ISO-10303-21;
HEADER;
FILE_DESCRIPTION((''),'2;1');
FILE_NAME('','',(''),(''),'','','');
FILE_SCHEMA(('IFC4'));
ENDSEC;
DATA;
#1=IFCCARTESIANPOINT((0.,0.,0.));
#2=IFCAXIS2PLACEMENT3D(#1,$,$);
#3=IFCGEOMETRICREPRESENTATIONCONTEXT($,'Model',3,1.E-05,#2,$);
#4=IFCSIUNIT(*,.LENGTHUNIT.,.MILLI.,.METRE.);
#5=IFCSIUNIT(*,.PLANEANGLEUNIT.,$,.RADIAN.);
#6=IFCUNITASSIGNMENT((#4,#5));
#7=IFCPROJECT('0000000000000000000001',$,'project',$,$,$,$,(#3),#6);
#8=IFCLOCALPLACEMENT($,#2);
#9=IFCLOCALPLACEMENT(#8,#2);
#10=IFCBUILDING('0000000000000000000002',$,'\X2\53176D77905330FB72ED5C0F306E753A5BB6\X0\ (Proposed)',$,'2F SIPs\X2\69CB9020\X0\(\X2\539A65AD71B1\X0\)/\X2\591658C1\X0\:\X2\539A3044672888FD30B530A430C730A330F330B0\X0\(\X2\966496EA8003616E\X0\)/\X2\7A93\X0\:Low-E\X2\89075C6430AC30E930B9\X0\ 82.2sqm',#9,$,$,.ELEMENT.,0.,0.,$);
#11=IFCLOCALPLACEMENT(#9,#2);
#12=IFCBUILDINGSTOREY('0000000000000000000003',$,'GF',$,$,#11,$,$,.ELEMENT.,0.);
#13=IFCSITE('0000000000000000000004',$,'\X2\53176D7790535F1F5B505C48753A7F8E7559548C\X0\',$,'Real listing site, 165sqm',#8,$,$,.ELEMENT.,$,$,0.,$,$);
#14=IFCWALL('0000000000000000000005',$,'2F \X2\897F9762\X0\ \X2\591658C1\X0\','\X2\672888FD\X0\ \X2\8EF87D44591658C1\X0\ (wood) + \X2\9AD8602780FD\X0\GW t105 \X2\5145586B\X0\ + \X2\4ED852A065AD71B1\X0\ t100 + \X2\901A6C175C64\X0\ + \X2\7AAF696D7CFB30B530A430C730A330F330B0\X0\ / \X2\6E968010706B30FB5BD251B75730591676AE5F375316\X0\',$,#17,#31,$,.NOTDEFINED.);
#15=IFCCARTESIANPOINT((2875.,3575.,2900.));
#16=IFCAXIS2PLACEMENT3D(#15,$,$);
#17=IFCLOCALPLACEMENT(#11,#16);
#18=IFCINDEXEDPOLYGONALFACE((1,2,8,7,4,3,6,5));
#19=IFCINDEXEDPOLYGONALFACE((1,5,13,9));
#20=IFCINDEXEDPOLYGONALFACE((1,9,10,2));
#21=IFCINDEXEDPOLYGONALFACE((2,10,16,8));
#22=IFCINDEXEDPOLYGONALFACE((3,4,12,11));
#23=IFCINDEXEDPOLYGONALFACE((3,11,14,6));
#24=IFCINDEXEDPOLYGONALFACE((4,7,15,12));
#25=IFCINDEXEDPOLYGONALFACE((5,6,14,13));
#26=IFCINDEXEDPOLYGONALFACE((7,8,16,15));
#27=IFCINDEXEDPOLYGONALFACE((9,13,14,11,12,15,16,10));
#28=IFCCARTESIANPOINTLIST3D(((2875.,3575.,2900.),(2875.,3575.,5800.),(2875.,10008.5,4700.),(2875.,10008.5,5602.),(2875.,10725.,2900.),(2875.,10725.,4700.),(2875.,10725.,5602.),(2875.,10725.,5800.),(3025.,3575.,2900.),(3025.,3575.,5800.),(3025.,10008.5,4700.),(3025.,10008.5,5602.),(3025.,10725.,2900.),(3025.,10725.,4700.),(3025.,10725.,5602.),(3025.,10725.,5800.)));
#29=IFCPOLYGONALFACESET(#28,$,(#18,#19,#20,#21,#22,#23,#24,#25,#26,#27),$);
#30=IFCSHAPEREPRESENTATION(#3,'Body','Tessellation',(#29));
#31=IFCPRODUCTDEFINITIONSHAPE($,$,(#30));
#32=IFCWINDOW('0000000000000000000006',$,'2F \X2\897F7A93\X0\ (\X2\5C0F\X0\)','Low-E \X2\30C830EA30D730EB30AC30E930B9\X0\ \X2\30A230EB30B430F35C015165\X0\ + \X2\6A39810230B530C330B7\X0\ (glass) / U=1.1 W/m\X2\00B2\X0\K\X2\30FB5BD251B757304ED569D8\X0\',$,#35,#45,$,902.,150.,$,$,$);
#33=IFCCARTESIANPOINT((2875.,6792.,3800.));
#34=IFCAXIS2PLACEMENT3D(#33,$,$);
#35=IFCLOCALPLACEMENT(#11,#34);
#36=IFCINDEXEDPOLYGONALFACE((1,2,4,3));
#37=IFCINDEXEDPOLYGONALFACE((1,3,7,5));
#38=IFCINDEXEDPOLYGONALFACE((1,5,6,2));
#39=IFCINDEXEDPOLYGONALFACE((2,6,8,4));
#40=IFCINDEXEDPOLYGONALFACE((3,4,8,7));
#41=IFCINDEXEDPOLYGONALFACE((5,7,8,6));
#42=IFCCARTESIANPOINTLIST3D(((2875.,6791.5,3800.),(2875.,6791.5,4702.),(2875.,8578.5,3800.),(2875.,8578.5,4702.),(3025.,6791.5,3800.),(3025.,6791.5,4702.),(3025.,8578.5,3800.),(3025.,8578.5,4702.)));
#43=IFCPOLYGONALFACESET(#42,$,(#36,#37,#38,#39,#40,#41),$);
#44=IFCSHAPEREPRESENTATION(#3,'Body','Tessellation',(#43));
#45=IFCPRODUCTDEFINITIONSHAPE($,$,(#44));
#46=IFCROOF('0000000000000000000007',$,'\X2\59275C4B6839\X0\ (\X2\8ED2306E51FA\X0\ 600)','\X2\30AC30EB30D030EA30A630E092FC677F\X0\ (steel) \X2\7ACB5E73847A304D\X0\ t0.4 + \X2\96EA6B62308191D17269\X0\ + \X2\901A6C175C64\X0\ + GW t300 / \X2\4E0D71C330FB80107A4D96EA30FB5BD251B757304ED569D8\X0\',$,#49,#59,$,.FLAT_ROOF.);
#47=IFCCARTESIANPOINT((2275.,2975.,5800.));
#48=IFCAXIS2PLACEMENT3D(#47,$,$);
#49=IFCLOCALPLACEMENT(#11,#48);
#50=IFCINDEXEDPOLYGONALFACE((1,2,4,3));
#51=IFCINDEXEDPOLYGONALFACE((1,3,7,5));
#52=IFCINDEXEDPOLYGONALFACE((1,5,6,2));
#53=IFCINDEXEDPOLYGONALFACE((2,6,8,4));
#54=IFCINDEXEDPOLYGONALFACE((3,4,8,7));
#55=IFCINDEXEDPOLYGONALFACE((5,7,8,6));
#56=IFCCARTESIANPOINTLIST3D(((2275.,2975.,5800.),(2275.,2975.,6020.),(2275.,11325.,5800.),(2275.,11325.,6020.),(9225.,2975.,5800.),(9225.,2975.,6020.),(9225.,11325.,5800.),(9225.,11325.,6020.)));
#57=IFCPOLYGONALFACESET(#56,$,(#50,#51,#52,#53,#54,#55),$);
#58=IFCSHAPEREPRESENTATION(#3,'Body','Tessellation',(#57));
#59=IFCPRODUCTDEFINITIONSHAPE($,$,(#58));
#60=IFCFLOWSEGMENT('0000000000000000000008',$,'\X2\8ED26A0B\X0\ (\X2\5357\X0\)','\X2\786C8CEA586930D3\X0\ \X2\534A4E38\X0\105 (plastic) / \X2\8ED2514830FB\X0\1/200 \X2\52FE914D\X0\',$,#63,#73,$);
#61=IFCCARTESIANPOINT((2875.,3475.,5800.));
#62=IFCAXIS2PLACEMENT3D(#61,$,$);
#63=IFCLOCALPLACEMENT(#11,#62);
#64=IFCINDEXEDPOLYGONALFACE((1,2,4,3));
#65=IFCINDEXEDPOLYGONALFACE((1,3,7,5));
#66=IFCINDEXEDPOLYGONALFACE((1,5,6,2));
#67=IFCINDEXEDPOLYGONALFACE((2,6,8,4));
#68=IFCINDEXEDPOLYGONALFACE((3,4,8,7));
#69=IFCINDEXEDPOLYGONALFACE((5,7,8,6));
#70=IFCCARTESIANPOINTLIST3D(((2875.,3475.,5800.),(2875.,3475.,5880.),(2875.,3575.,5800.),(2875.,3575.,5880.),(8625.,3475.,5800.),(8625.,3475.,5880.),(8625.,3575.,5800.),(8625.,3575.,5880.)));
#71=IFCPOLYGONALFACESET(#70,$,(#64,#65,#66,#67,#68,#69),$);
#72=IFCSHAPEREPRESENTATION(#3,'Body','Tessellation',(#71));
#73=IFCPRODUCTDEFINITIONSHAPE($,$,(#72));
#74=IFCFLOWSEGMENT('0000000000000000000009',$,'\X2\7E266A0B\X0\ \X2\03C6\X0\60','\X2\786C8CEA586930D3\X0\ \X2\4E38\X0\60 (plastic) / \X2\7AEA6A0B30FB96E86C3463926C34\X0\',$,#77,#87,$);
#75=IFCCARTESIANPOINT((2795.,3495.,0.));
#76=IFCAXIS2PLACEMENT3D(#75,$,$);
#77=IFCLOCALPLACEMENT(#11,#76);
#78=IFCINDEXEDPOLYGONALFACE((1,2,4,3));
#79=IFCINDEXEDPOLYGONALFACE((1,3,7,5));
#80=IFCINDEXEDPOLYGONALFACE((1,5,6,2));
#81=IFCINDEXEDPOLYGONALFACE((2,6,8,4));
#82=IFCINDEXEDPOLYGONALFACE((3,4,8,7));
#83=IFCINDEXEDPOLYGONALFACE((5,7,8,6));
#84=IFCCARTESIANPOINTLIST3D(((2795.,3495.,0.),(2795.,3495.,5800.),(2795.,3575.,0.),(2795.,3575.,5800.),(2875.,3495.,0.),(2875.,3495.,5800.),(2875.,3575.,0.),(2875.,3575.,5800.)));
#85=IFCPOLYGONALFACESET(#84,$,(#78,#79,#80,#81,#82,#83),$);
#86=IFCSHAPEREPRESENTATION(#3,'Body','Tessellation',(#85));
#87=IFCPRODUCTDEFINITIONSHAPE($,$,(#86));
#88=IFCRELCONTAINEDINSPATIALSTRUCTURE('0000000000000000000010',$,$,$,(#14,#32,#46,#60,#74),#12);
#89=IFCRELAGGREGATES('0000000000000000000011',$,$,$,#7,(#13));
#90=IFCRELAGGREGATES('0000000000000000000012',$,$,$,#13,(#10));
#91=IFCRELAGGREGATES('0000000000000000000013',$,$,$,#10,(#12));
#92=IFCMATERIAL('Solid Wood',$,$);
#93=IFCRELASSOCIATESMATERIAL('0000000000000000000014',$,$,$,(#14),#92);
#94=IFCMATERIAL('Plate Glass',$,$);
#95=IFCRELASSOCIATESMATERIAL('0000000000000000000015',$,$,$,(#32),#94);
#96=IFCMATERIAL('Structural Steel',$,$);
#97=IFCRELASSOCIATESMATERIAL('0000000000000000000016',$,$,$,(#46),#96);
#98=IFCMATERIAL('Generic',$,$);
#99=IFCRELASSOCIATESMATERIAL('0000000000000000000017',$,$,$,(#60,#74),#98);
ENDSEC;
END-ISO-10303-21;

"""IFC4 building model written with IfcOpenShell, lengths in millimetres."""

from ifc_helpers import new_model, si_unit, frame, frame_2d, origin, place, context, project, spatial, rectangle, extrude, material, element, fill, save


model = new_model("IFC4")

# Units and contexts
model_context = context("Model", 3, precision=1e-05, world=origin())
ifc_project = project(units=[si_unit("LENGTHUNIT", "METRE", prefix="MILLI"), si_unit("PLANEANGLEUNIT", "RADIAN")], contexts=[model_context])

# Site, building, storey
site_placement = place(None, origin())
site = spatial("IfcSite", under=ifc_project, at=site_placement, Name="北海道弟子屈町美留和", ObjectType="Real listing site, 165sqm", CompositionType="ELEMENT", RefElevation=0.0)
building_placement = place(site_placement, origin())
building = spatial("IfcBuilding", under=site, at=building_placement, Name="北海道・狭小の町家 (Proposed)", ObjectType="2F SIPs構造(厚断熱)/外壁:厚い木製サイディング(除雪考慮)/窓:Low-E複層ガラス 82.2sqm", CompositionType="ELEMENT", ElevationOfRefHeight=0.0, ElevationOfTerrain=0.0)
storey_placement = place(building_placement, origin())
storey = spatial("IfcBuildingStorey", under=building, at=storey_placement, Name="GF", CompositionType="ELEMENT", Elevation=0.0)

# Shared definitions
ifc_material_1 = material(Name="Solid Wood")

# Shared definitions
ifc_material_2 = material(Name="Plate Glass")

# Wall, opening, window
wall_1_placement = place(storey_placement, frame((2875.0, 3575.0, 2900.0)))
wall_1 = element("IfcWall", 1, at=wall_1_placement, inside=storey, material=ifc_material_1, Name="2F 西面 外壁", Description="木製 軸組外壁 (wood) + 高性能GW t105 充填 + 付加断熱 t100 + 通気層 + 窯業系サイディング / 準耐火・寒冷地外皮強化", PredefinedType="NOTDEFINED", context=model_context, shape_type="SweptSolid", body=[
    extrude(rectangle(XDim=150.0, YDim=7150.0, at=frame_2d((75.0, 3575.0))), frame((2875.0, 3575.0, 2900.0)), (0.0, 0.0, 1.0), 2900.0),
])
opening_1_placement = place(storey_placement, frame((2875.0, 6792.0, 3800.0)))
opening_1 = element("IfcOpeningElement", 2, at=opening_1_placement, cuts=wall_1, PredefinedType="NOTDEFINED", context=model_context, shape_type="SweptSolid", body=[
    extrude(rectangle(XDim=150.0, YDim=1787.0, at=frame_2d((75.0, 893.0))), frame((2875.0, 6792.0, 3800.0)), (0.0, 0.0, 1.0), 902.0),
])
window_1_placement = place(storey_placement, frame((2875.0, 6792.0, 3800.0)))
window_1 = element("IfcWindow", 3, at=window_1_placement, inside=storey, material=ifc_material_2, Name="2F 西窓 (小)", Description="Low-E トリプルガラス アルゴン封入 + 樹脂サッシ (glass) / U=1.1 W/m²K・寒冷地仕様", OverallHeight=902.0, OverallWidth=150.0, context=model_context, shape_type="SweptSolid", body=[
    extrude(rectangle(XDim=150.0, YDim=1787.0, at=frame_2d((75.0, 893.0))), frame((2875.0, 6792.0, 3800.0)), (0.0, 0.0, 1.0), 902.0),
])
fill(opening_1, window_1)

# Roof
ifc_material_3 = material(Name="Structural Steel")
roof_placement = place(storey_placement, frame((2275.0, 2975.0, 5800.0)))
element("IfcRoof", 4, at=roof_placement, inside=storey, material=ifc_material_3, Name="大屋根 (軒の出 600)", Description="ガルバリウム鋼板 (steel) 立平葺き t0.4 + 雪止め金物 + 通気層 + GW t300 / 不燃・耐積雪・寒冷地仕様", PredefinedType="FLAT_ROOF", context=model_context, shape_type="SweptSolid", body=[
    extrude(rectangle(XDim=6950.0, YDim=8350.0, at=frame_2d((3475.0, 4175.0))), frame((2275.0, 2975.0, 5800.0)), (0.0, 0.0, 1.0), 220.0),
])

# Flow segments
ifc_material_4 = material(Name="Generic")
flow_segment_1_placement = place(storey_placement, frame((2875.0, 3475.0, 5800.0)))
element("IfcFlowSegment", 5, at=flow_segment_1_placement, inside=storey, material=ifc_material_4, Name="軒樋 (南)", Description="硬質塩ビ 半丸105 (plastic) / 軒先・1/200 勾配", context=model_context, shape_type="SweptSolid", body=[
    extrude(rectangle(XDim=5750.0, YDim=100.0, at=frame_2d((2875.0, 50.0))), frame((2875.0, 3475.0, 5800.0)), (0.0, 0.0, 1.0), 80.0),
])
flow_segment_2_placement = place(storey_placement, frame((2795.0, 3495.0, 0.0)))
element("IfcFlowSegment", 6, at=flow_segment_2_placement, inside=storey, material=ifc_material_4, Name="縦樋 φ60", Description="硬質塩ビ 丸60 (plastic) / 竪樋・雨水排水", context=model_context, shape_type="SweptSolid", body=[
    extrude(rectangle(XDim=80.0, YDim=80.0, at=frame_2d((40.0, 40.0))), frame((2795.0, 3495.0, 0.0)), (0.0, 0.0, 1.0), 5800.0),
])

save(model, "model.ifc")
